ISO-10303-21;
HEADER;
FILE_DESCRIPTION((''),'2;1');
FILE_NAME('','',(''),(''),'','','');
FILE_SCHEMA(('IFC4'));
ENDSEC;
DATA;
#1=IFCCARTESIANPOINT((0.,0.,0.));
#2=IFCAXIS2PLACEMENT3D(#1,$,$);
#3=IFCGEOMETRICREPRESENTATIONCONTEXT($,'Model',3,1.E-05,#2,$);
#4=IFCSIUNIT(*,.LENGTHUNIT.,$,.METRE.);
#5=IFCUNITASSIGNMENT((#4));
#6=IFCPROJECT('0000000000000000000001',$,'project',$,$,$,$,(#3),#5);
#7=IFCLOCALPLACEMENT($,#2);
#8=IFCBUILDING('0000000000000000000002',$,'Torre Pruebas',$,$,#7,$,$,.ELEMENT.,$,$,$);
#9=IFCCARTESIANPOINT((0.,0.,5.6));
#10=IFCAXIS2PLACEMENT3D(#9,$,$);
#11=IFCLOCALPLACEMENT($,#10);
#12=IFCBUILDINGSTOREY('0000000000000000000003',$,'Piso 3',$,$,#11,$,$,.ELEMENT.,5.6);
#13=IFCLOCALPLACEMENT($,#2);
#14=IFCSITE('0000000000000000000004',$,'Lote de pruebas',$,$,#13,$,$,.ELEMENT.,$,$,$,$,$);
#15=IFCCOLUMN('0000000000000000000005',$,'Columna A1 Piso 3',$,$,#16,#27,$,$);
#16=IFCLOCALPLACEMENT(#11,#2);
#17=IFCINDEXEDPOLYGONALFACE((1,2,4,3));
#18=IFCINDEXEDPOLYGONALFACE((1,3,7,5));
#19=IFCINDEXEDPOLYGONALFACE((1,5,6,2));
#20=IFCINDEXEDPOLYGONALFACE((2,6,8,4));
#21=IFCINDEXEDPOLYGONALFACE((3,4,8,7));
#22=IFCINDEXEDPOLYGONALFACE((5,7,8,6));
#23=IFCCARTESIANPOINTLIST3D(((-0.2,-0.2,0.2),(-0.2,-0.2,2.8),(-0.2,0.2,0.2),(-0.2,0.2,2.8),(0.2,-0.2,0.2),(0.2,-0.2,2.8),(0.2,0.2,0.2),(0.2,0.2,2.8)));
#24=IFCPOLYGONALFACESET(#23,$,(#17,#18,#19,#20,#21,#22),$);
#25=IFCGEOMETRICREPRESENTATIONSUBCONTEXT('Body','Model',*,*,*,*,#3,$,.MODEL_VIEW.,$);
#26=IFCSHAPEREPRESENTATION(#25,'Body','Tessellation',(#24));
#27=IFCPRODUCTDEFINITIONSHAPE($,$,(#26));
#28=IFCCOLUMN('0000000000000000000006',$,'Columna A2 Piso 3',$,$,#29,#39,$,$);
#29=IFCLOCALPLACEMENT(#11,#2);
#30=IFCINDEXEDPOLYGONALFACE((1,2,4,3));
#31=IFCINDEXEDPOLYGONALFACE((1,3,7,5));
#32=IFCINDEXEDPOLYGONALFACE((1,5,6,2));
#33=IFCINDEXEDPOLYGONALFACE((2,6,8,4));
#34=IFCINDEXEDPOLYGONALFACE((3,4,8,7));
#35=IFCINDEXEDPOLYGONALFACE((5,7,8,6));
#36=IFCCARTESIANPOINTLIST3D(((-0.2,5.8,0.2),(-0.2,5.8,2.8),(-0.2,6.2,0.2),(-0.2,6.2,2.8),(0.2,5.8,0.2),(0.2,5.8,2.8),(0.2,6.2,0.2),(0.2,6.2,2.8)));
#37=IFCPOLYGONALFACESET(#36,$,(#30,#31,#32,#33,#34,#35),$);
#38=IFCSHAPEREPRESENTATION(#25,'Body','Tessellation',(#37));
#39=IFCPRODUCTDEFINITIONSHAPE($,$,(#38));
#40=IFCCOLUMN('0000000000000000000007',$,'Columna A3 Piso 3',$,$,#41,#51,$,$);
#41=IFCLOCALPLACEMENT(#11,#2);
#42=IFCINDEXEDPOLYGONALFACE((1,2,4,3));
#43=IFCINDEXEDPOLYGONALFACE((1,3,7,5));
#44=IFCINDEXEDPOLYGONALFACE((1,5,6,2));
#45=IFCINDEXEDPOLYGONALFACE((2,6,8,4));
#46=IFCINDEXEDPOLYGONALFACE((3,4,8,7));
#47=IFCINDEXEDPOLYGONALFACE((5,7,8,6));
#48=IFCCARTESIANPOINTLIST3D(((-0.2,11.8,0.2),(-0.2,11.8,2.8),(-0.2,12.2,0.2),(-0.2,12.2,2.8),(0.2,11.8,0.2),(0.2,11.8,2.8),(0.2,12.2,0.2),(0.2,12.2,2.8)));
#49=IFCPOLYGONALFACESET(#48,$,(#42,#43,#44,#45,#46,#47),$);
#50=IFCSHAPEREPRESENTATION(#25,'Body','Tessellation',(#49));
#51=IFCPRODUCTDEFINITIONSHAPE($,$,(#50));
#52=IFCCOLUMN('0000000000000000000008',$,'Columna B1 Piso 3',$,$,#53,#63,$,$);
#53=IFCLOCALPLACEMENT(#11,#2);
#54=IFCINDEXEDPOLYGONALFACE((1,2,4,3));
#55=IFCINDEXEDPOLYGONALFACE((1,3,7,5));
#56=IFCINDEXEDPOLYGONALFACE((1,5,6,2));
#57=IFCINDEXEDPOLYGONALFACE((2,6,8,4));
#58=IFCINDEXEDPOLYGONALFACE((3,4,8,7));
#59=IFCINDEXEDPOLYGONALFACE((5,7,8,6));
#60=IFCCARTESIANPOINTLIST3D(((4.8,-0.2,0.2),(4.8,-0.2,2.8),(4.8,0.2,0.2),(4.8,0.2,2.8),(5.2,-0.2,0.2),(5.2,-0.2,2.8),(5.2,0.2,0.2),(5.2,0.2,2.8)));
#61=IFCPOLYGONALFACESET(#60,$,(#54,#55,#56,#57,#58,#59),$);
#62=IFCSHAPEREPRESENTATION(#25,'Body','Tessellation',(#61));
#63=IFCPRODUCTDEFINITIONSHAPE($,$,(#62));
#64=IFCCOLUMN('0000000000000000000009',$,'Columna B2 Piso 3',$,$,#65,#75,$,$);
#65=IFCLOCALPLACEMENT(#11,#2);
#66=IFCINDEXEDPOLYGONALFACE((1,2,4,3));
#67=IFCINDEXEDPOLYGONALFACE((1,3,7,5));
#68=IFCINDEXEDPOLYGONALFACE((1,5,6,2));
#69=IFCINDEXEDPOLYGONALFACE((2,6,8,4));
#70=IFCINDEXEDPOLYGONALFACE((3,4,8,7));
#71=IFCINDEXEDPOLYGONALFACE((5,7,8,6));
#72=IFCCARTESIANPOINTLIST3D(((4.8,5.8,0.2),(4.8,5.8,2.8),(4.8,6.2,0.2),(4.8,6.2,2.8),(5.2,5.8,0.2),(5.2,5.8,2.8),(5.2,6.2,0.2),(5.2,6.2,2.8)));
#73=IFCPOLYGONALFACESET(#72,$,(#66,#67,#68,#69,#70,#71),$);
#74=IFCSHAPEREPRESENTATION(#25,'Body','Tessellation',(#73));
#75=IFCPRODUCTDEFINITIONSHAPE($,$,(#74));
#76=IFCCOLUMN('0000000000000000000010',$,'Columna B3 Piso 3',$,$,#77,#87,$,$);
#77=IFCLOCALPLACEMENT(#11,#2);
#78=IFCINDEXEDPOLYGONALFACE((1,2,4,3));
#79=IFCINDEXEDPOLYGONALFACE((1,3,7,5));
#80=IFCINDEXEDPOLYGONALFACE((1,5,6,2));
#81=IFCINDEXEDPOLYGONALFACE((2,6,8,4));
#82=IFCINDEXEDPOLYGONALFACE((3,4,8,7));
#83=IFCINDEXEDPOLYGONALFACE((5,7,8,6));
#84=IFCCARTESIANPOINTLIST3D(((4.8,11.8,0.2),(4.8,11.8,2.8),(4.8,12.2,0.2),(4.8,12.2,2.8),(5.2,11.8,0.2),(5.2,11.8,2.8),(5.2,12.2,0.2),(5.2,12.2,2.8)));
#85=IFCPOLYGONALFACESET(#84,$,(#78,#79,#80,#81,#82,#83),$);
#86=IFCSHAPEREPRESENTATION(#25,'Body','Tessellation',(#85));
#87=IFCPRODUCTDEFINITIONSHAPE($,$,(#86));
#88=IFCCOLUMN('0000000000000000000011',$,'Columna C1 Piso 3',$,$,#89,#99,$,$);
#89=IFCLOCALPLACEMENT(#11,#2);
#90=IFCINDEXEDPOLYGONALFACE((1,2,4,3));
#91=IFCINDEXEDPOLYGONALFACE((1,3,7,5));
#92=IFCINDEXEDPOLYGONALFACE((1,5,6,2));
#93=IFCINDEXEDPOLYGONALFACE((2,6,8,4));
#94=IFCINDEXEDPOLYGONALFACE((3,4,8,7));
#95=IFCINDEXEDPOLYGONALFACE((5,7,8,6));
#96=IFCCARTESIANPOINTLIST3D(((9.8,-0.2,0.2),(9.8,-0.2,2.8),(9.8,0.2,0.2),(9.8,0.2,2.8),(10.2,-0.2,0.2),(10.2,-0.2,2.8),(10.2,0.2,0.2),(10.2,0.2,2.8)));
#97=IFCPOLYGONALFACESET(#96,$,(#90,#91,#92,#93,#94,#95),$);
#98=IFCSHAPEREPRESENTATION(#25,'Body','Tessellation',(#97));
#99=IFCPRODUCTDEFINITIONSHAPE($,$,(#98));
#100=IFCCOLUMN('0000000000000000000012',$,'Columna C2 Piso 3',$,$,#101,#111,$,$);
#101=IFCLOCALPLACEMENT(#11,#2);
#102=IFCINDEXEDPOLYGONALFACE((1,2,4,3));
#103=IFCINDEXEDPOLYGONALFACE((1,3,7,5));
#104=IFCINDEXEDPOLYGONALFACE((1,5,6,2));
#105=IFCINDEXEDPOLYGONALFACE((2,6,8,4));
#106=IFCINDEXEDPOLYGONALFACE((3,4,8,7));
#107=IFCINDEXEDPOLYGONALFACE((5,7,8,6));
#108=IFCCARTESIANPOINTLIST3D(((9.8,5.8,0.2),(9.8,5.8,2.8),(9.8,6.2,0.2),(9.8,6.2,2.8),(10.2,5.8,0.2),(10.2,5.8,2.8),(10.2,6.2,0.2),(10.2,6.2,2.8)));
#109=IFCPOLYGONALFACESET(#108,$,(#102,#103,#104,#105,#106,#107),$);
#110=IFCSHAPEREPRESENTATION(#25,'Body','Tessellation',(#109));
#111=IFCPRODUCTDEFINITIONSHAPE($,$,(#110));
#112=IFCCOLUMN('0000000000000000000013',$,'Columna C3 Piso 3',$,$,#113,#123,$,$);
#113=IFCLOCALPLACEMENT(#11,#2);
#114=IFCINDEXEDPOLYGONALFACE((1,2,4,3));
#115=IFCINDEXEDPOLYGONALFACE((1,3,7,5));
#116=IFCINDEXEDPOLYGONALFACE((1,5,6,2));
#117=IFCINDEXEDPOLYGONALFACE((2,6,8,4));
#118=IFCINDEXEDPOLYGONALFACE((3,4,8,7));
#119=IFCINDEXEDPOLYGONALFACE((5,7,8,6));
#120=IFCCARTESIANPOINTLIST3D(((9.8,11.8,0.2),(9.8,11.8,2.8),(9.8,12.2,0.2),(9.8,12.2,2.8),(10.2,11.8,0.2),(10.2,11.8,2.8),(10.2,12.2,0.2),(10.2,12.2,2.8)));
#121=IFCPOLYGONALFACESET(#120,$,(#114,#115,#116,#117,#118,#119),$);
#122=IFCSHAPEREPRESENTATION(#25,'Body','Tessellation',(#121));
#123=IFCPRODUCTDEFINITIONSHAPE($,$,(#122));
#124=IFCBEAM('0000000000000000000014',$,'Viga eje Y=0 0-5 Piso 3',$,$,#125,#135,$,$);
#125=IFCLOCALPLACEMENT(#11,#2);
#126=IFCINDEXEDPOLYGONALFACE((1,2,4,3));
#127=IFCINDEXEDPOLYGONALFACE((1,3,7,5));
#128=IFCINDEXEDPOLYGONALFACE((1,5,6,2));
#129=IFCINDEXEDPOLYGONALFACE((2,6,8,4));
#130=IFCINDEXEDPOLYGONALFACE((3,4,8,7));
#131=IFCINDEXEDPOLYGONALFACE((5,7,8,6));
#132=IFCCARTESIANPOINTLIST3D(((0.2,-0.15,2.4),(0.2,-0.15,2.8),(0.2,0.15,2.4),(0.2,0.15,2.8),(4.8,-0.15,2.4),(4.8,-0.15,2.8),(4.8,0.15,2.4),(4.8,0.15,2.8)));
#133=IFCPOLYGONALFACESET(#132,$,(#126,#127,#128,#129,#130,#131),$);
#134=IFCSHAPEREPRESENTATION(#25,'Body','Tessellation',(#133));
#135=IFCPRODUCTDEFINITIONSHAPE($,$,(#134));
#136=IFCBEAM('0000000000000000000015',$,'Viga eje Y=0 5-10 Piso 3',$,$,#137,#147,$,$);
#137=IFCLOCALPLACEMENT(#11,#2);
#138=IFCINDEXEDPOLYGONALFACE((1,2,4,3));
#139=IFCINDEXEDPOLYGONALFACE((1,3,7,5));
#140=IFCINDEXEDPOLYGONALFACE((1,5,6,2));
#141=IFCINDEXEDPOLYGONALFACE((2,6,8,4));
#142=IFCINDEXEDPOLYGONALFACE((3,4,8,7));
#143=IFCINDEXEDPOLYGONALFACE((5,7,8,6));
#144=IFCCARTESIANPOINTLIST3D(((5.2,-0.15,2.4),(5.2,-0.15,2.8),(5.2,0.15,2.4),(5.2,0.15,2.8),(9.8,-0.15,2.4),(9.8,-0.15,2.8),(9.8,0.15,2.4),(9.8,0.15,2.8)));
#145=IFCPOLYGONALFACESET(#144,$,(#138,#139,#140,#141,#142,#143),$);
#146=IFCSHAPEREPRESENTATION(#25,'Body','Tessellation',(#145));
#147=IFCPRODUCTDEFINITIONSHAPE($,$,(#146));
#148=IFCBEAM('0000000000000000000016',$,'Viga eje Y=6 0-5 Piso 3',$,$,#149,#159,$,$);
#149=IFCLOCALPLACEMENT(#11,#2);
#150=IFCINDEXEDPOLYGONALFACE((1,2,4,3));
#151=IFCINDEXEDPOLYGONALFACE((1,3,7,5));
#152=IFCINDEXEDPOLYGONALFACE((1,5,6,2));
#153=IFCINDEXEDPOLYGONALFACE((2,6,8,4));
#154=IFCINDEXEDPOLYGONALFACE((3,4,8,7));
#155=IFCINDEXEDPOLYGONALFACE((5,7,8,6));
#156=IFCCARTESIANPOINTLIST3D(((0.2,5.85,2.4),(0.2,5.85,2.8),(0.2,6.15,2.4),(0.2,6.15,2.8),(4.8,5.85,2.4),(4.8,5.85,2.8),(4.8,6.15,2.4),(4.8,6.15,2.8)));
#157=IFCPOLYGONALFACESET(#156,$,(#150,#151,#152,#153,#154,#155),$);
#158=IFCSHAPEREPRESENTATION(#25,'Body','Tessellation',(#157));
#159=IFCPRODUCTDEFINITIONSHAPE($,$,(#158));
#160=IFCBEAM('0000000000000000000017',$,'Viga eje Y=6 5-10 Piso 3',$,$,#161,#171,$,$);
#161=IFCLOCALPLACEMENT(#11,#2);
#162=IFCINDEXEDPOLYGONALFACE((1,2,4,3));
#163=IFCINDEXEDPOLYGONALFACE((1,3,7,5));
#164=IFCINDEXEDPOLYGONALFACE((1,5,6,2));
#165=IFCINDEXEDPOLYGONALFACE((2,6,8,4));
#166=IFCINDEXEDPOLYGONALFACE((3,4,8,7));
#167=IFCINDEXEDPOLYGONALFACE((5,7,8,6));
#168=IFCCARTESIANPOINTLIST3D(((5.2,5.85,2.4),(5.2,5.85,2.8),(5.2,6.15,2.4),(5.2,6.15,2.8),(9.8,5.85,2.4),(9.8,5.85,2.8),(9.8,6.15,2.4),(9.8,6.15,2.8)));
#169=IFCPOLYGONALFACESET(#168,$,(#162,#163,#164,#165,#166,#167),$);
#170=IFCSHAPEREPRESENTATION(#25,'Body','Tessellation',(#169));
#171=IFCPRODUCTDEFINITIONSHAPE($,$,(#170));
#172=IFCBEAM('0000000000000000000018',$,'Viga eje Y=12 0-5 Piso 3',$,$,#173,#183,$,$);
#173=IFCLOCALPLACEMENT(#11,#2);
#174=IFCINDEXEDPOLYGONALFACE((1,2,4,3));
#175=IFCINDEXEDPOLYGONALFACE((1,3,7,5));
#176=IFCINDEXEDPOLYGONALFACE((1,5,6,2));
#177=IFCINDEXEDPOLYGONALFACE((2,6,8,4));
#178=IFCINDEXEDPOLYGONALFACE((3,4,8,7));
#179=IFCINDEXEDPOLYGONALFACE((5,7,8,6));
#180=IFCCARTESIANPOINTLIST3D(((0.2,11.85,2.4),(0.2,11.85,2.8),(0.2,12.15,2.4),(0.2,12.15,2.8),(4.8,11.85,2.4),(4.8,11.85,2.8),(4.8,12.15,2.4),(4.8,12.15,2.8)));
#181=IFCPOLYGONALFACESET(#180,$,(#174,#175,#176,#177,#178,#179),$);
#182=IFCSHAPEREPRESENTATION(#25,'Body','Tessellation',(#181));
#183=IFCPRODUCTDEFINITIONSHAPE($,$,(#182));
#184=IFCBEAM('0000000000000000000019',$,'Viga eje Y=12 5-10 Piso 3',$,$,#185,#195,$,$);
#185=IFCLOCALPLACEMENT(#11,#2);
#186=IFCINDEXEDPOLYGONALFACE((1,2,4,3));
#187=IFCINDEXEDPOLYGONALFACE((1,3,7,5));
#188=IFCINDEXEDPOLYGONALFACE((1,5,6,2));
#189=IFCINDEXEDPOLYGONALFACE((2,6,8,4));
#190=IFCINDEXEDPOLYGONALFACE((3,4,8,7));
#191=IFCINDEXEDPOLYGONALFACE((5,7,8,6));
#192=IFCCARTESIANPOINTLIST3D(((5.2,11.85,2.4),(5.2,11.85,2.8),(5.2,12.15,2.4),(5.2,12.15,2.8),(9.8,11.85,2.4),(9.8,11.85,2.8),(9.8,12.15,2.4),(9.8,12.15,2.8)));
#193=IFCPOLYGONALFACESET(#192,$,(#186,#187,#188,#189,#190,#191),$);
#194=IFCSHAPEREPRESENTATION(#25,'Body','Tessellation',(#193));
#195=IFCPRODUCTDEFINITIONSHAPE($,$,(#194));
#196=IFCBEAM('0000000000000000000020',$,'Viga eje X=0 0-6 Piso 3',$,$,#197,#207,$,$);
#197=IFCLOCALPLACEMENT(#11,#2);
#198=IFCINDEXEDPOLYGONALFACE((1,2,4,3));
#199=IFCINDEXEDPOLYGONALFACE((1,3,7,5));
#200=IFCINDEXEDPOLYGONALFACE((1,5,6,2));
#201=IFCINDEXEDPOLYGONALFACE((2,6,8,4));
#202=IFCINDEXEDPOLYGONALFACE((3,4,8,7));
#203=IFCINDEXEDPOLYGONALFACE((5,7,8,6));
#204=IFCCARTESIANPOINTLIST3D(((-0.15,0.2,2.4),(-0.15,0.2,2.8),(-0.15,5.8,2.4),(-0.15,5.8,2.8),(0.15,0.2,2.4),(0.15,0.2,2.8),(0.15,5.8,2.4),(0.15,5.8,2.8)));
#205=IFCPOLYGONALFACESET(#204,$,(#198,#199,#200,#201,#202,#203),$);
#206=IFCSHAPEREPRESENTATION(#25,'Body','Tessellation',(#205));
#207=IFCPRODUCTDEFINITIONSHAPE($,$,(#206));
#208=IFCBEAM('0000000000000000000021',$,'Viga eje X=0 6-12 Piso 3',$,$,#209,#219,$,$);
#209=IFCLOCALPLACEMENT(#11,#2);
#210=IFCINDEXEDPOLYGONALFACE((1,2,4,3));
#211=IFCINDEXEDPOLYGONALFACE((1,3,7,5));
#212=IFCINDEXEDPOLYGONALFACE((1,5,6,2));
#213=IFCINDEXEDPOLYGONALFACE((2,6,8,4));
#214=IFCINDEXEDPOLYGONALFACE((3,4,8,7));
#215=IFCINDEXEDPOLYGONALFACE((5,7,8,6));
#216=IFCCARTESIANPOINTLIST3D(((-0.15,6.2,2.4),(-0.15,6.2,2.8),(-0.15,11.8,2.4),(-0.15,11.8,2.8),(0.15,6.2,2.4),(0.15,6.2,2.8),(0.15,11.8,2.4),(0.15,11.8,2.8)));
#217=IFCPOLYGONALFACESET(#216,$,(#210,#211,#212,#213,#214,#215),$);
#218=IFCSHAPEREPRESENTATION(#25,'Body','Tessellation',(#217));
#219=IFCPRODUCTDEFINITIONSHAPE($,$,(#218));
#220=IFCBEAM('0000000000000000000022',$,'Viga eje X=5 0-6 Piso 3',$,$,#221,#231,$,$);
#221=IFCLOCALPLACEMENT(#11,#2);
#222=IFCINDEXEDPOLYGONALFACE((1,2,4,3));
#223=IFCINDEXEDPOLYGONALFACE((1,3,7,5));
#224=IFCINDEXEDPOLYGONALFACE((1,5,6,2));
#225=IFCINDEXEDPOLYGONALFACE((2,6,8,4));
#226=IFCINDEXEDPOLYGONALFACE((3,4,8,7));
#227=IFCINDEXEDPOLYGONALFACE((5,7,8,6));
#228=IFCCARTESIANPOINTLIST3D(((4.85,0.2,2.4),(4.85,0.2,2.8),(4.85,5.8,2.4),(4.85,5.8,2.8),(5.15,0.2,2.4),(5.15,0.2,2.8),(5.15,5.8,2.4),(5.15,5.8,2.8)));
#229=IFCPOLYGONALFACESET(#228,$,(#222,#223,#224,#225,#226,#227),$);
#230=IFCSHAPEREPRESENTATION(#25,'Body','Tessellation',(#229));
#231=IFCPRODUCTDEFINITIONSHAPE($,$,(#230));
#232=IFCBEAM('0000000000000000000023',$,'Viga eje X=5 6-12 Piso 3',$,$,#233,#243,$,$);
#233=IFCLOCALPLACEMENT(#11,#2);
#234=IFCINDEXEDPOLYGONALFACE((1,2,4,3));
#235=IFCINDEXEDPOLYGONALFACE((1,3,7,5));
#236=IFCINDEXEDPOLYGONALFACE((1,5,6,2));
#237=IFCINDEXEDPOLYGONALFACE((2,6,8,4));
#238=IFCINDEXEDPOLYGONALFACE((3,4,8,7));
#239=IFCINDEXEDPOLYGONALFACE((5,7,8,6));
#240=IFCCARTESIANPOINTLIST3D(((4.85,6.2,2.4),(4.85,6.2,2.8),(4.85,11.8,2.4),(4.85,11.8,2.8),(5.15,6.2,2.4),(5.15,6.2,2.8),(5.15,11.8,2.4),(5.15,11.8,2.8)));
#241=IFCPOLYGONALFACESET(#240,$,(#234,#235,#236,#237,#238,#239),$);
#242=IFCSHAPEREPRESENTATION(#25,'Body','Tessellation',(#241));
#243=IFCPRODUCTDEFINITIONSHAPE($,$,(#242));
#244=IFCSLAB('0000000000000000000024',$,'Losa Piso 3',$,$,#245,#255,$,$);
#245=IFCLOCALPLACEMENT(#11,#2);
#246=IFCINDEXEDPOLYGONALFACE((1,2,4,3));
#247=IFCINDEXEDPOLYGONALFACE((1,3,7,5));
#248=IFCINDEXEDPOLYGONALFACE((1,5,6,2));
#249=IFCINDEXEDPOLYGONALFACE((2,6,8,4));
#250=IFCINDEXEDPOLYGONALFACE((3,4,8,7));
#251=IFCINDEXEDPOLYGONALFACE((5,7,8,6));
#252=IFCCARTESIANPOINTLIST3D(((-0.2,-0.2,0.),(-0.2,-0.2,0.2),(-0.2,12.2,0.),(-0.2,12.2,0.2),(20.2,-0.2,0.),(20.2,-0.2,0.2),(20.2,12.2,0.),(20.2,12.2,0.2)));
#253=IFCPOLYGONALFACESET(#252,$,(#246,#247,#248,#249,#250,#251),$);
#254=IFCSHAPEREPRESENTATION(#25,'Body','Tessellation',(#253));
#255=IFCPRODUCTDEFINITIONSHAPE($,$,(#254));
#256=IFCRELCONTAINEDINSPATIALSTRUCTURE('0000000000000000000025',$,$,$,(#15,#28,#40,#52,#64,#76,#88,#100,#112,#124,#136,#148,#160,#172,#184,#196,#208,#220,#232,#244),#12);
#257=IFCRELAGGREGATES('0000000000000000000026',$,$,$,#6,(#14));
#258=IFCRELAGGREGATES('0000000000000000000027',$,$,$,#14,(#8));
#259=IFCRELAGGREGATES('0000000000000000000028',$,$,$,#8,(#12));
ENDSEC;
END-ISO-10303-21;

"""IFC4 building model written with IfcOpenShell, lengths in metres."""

from ifc_helpers import new_model, si_unit, frame, origin, origin_2d, place, context, subcontext, project, spatial, rectangle, extrude, element, save


model = new_model("IFC4")

# Units and contexts
model_context = context("Model", 3, precision=1e-05, world=origin())
body_context = subcontext(model_context, "Body", "Model", "MODEL_VIEW")
ifc_project = project(units=[si_unit("LENGTHUNIT", "METRE")], contexts=[model_context])

# Site, building, storey
site_placement = place(None, origin())
site = spatial("IfcSite", under=ifc_project, at=site_placement, Name="Lote de pruebas", CompositionType="ELEMENT")
building_placement = place(None, origin())
building = spatial("IfcBuilding", under=site, at=building_placement, Name="Torre Pruebas", CompositionType="ELEMENT")
storey_placement = place(None, frame((0.0, 0.0, 5.6)))
storey = spatial("IfcBuildingStorey", under=building, at=storey_placement, Name="Piso 3", CompositionType="ELEMENT", Elevation=5.6)

# Columns
for number, where, name in (
    (1, (0.0, 0.0, 5.8), "Columna A1 Piso 3"),
    (2, (0.0, 6.0, 5.8), "Columna A2 Piso 3"),
    (3, (0.0, 12.0, 5.8), "Columna A3 Piso 3"),
    (4, (5.0, 0.0, 5.8), "Columna B1 Piso 3"),
    (5, (5.0, 6.0, 5.8), "Columna B2 Piso 3"),
    (6, (5.0, 12.0, 5.8), "Columna B3 Piso 3"),
    (7, (10.0, 0.0, 5.8), "Columna C1 Piso 3"),
    (8, (10.0, 6.0, 5.8), "Columna C2 Piso 3"),
    (9, (10.0, 12.0, 5.8), "Columna C3 Piso 3"),
):
    element("IfcColumn", number, at=place(None, frame(where)), inside=storey, Name=name, context=body_context, shape_type="SweptSolid", body=[
        extrude(rectangle(XDim=0.4, YDim=0.4, at=origin_2d()), origin(), (0.0, 0.0, 1.0), 2.6),
    ])

# Beams
for number, where, name in (
    (10, (2.5, 0.0, 8.0), "Viga eje Y=0 0-5 Piso 3"),
    (11, (7.5, 0.0, 8.0), "Viga eje Y=0 5-10 Piso 3"),
    (12, (2.5, 6.0, 8.0), "Viga eje Y=6 0-5 Piso 3"),
    (13, (7.5, 6.0, 8.0), "Viga eje Y=6 5-10 Piso 3"),
    (14, (2.5, 12.0, 8.0), "Viga eje Y=12 0-5 Piso 3"),
    (15, (7.5, 12.0, 8.0), "Viga eje Y=12 5-10 Piso 3"),
):
    element("IfcBeam", number, at=place(None, frame(where)), inside=storey, Name=name, context=body_context, shape_type="SweptSolid", body=[
        extrude(rectangle(XDim=4.6, YDim=0.3, at=origin_2d()), origin(), (0.0, 0.0, 1.0), 0.4),
    ])
for number, where, name in (
    (16, (0.0, 3.0, 8.0), "Viga eje X=0 0-6 Piso 3"),
    (17, (0.0, 9.0, 8.0), "Viga eje X=0 6-12 Piso 3"),
    (18, (5.0, 3.0, 8.0), "Viga eje X=5 0-6 Piso 3"),
    (19, (5.0, 9.0, 8.0), "Viga eje X=5 6-12 Piso 3"),
):
    element("IfcBeam", number, at=place(None, frame(where)), inside=storey, Name=name, context=body_context, shape_type="SweptSolid", body=[
        extrude(rectangle(XDim=0.3, YDim=5.6, at=origin_2d()), origin(), (0.0, 0.0, 1.0), 0.4),
    ])

# Slab
slab_placement = place(None, frame((10.0, 6.0, 5.6)))
element("IfcSlab", 20, at=slab_placement, inside=storey, Name="Losa Piso 3", context=body_context, shape_type="SweptSolid", body=[
    extrude(rectangle(XDim=20.4, YDim=12.4, at=origin_2d()), origin(), (0.0, 0.0, 1.0), 0.2),
])

save(model, "model.ifc")
